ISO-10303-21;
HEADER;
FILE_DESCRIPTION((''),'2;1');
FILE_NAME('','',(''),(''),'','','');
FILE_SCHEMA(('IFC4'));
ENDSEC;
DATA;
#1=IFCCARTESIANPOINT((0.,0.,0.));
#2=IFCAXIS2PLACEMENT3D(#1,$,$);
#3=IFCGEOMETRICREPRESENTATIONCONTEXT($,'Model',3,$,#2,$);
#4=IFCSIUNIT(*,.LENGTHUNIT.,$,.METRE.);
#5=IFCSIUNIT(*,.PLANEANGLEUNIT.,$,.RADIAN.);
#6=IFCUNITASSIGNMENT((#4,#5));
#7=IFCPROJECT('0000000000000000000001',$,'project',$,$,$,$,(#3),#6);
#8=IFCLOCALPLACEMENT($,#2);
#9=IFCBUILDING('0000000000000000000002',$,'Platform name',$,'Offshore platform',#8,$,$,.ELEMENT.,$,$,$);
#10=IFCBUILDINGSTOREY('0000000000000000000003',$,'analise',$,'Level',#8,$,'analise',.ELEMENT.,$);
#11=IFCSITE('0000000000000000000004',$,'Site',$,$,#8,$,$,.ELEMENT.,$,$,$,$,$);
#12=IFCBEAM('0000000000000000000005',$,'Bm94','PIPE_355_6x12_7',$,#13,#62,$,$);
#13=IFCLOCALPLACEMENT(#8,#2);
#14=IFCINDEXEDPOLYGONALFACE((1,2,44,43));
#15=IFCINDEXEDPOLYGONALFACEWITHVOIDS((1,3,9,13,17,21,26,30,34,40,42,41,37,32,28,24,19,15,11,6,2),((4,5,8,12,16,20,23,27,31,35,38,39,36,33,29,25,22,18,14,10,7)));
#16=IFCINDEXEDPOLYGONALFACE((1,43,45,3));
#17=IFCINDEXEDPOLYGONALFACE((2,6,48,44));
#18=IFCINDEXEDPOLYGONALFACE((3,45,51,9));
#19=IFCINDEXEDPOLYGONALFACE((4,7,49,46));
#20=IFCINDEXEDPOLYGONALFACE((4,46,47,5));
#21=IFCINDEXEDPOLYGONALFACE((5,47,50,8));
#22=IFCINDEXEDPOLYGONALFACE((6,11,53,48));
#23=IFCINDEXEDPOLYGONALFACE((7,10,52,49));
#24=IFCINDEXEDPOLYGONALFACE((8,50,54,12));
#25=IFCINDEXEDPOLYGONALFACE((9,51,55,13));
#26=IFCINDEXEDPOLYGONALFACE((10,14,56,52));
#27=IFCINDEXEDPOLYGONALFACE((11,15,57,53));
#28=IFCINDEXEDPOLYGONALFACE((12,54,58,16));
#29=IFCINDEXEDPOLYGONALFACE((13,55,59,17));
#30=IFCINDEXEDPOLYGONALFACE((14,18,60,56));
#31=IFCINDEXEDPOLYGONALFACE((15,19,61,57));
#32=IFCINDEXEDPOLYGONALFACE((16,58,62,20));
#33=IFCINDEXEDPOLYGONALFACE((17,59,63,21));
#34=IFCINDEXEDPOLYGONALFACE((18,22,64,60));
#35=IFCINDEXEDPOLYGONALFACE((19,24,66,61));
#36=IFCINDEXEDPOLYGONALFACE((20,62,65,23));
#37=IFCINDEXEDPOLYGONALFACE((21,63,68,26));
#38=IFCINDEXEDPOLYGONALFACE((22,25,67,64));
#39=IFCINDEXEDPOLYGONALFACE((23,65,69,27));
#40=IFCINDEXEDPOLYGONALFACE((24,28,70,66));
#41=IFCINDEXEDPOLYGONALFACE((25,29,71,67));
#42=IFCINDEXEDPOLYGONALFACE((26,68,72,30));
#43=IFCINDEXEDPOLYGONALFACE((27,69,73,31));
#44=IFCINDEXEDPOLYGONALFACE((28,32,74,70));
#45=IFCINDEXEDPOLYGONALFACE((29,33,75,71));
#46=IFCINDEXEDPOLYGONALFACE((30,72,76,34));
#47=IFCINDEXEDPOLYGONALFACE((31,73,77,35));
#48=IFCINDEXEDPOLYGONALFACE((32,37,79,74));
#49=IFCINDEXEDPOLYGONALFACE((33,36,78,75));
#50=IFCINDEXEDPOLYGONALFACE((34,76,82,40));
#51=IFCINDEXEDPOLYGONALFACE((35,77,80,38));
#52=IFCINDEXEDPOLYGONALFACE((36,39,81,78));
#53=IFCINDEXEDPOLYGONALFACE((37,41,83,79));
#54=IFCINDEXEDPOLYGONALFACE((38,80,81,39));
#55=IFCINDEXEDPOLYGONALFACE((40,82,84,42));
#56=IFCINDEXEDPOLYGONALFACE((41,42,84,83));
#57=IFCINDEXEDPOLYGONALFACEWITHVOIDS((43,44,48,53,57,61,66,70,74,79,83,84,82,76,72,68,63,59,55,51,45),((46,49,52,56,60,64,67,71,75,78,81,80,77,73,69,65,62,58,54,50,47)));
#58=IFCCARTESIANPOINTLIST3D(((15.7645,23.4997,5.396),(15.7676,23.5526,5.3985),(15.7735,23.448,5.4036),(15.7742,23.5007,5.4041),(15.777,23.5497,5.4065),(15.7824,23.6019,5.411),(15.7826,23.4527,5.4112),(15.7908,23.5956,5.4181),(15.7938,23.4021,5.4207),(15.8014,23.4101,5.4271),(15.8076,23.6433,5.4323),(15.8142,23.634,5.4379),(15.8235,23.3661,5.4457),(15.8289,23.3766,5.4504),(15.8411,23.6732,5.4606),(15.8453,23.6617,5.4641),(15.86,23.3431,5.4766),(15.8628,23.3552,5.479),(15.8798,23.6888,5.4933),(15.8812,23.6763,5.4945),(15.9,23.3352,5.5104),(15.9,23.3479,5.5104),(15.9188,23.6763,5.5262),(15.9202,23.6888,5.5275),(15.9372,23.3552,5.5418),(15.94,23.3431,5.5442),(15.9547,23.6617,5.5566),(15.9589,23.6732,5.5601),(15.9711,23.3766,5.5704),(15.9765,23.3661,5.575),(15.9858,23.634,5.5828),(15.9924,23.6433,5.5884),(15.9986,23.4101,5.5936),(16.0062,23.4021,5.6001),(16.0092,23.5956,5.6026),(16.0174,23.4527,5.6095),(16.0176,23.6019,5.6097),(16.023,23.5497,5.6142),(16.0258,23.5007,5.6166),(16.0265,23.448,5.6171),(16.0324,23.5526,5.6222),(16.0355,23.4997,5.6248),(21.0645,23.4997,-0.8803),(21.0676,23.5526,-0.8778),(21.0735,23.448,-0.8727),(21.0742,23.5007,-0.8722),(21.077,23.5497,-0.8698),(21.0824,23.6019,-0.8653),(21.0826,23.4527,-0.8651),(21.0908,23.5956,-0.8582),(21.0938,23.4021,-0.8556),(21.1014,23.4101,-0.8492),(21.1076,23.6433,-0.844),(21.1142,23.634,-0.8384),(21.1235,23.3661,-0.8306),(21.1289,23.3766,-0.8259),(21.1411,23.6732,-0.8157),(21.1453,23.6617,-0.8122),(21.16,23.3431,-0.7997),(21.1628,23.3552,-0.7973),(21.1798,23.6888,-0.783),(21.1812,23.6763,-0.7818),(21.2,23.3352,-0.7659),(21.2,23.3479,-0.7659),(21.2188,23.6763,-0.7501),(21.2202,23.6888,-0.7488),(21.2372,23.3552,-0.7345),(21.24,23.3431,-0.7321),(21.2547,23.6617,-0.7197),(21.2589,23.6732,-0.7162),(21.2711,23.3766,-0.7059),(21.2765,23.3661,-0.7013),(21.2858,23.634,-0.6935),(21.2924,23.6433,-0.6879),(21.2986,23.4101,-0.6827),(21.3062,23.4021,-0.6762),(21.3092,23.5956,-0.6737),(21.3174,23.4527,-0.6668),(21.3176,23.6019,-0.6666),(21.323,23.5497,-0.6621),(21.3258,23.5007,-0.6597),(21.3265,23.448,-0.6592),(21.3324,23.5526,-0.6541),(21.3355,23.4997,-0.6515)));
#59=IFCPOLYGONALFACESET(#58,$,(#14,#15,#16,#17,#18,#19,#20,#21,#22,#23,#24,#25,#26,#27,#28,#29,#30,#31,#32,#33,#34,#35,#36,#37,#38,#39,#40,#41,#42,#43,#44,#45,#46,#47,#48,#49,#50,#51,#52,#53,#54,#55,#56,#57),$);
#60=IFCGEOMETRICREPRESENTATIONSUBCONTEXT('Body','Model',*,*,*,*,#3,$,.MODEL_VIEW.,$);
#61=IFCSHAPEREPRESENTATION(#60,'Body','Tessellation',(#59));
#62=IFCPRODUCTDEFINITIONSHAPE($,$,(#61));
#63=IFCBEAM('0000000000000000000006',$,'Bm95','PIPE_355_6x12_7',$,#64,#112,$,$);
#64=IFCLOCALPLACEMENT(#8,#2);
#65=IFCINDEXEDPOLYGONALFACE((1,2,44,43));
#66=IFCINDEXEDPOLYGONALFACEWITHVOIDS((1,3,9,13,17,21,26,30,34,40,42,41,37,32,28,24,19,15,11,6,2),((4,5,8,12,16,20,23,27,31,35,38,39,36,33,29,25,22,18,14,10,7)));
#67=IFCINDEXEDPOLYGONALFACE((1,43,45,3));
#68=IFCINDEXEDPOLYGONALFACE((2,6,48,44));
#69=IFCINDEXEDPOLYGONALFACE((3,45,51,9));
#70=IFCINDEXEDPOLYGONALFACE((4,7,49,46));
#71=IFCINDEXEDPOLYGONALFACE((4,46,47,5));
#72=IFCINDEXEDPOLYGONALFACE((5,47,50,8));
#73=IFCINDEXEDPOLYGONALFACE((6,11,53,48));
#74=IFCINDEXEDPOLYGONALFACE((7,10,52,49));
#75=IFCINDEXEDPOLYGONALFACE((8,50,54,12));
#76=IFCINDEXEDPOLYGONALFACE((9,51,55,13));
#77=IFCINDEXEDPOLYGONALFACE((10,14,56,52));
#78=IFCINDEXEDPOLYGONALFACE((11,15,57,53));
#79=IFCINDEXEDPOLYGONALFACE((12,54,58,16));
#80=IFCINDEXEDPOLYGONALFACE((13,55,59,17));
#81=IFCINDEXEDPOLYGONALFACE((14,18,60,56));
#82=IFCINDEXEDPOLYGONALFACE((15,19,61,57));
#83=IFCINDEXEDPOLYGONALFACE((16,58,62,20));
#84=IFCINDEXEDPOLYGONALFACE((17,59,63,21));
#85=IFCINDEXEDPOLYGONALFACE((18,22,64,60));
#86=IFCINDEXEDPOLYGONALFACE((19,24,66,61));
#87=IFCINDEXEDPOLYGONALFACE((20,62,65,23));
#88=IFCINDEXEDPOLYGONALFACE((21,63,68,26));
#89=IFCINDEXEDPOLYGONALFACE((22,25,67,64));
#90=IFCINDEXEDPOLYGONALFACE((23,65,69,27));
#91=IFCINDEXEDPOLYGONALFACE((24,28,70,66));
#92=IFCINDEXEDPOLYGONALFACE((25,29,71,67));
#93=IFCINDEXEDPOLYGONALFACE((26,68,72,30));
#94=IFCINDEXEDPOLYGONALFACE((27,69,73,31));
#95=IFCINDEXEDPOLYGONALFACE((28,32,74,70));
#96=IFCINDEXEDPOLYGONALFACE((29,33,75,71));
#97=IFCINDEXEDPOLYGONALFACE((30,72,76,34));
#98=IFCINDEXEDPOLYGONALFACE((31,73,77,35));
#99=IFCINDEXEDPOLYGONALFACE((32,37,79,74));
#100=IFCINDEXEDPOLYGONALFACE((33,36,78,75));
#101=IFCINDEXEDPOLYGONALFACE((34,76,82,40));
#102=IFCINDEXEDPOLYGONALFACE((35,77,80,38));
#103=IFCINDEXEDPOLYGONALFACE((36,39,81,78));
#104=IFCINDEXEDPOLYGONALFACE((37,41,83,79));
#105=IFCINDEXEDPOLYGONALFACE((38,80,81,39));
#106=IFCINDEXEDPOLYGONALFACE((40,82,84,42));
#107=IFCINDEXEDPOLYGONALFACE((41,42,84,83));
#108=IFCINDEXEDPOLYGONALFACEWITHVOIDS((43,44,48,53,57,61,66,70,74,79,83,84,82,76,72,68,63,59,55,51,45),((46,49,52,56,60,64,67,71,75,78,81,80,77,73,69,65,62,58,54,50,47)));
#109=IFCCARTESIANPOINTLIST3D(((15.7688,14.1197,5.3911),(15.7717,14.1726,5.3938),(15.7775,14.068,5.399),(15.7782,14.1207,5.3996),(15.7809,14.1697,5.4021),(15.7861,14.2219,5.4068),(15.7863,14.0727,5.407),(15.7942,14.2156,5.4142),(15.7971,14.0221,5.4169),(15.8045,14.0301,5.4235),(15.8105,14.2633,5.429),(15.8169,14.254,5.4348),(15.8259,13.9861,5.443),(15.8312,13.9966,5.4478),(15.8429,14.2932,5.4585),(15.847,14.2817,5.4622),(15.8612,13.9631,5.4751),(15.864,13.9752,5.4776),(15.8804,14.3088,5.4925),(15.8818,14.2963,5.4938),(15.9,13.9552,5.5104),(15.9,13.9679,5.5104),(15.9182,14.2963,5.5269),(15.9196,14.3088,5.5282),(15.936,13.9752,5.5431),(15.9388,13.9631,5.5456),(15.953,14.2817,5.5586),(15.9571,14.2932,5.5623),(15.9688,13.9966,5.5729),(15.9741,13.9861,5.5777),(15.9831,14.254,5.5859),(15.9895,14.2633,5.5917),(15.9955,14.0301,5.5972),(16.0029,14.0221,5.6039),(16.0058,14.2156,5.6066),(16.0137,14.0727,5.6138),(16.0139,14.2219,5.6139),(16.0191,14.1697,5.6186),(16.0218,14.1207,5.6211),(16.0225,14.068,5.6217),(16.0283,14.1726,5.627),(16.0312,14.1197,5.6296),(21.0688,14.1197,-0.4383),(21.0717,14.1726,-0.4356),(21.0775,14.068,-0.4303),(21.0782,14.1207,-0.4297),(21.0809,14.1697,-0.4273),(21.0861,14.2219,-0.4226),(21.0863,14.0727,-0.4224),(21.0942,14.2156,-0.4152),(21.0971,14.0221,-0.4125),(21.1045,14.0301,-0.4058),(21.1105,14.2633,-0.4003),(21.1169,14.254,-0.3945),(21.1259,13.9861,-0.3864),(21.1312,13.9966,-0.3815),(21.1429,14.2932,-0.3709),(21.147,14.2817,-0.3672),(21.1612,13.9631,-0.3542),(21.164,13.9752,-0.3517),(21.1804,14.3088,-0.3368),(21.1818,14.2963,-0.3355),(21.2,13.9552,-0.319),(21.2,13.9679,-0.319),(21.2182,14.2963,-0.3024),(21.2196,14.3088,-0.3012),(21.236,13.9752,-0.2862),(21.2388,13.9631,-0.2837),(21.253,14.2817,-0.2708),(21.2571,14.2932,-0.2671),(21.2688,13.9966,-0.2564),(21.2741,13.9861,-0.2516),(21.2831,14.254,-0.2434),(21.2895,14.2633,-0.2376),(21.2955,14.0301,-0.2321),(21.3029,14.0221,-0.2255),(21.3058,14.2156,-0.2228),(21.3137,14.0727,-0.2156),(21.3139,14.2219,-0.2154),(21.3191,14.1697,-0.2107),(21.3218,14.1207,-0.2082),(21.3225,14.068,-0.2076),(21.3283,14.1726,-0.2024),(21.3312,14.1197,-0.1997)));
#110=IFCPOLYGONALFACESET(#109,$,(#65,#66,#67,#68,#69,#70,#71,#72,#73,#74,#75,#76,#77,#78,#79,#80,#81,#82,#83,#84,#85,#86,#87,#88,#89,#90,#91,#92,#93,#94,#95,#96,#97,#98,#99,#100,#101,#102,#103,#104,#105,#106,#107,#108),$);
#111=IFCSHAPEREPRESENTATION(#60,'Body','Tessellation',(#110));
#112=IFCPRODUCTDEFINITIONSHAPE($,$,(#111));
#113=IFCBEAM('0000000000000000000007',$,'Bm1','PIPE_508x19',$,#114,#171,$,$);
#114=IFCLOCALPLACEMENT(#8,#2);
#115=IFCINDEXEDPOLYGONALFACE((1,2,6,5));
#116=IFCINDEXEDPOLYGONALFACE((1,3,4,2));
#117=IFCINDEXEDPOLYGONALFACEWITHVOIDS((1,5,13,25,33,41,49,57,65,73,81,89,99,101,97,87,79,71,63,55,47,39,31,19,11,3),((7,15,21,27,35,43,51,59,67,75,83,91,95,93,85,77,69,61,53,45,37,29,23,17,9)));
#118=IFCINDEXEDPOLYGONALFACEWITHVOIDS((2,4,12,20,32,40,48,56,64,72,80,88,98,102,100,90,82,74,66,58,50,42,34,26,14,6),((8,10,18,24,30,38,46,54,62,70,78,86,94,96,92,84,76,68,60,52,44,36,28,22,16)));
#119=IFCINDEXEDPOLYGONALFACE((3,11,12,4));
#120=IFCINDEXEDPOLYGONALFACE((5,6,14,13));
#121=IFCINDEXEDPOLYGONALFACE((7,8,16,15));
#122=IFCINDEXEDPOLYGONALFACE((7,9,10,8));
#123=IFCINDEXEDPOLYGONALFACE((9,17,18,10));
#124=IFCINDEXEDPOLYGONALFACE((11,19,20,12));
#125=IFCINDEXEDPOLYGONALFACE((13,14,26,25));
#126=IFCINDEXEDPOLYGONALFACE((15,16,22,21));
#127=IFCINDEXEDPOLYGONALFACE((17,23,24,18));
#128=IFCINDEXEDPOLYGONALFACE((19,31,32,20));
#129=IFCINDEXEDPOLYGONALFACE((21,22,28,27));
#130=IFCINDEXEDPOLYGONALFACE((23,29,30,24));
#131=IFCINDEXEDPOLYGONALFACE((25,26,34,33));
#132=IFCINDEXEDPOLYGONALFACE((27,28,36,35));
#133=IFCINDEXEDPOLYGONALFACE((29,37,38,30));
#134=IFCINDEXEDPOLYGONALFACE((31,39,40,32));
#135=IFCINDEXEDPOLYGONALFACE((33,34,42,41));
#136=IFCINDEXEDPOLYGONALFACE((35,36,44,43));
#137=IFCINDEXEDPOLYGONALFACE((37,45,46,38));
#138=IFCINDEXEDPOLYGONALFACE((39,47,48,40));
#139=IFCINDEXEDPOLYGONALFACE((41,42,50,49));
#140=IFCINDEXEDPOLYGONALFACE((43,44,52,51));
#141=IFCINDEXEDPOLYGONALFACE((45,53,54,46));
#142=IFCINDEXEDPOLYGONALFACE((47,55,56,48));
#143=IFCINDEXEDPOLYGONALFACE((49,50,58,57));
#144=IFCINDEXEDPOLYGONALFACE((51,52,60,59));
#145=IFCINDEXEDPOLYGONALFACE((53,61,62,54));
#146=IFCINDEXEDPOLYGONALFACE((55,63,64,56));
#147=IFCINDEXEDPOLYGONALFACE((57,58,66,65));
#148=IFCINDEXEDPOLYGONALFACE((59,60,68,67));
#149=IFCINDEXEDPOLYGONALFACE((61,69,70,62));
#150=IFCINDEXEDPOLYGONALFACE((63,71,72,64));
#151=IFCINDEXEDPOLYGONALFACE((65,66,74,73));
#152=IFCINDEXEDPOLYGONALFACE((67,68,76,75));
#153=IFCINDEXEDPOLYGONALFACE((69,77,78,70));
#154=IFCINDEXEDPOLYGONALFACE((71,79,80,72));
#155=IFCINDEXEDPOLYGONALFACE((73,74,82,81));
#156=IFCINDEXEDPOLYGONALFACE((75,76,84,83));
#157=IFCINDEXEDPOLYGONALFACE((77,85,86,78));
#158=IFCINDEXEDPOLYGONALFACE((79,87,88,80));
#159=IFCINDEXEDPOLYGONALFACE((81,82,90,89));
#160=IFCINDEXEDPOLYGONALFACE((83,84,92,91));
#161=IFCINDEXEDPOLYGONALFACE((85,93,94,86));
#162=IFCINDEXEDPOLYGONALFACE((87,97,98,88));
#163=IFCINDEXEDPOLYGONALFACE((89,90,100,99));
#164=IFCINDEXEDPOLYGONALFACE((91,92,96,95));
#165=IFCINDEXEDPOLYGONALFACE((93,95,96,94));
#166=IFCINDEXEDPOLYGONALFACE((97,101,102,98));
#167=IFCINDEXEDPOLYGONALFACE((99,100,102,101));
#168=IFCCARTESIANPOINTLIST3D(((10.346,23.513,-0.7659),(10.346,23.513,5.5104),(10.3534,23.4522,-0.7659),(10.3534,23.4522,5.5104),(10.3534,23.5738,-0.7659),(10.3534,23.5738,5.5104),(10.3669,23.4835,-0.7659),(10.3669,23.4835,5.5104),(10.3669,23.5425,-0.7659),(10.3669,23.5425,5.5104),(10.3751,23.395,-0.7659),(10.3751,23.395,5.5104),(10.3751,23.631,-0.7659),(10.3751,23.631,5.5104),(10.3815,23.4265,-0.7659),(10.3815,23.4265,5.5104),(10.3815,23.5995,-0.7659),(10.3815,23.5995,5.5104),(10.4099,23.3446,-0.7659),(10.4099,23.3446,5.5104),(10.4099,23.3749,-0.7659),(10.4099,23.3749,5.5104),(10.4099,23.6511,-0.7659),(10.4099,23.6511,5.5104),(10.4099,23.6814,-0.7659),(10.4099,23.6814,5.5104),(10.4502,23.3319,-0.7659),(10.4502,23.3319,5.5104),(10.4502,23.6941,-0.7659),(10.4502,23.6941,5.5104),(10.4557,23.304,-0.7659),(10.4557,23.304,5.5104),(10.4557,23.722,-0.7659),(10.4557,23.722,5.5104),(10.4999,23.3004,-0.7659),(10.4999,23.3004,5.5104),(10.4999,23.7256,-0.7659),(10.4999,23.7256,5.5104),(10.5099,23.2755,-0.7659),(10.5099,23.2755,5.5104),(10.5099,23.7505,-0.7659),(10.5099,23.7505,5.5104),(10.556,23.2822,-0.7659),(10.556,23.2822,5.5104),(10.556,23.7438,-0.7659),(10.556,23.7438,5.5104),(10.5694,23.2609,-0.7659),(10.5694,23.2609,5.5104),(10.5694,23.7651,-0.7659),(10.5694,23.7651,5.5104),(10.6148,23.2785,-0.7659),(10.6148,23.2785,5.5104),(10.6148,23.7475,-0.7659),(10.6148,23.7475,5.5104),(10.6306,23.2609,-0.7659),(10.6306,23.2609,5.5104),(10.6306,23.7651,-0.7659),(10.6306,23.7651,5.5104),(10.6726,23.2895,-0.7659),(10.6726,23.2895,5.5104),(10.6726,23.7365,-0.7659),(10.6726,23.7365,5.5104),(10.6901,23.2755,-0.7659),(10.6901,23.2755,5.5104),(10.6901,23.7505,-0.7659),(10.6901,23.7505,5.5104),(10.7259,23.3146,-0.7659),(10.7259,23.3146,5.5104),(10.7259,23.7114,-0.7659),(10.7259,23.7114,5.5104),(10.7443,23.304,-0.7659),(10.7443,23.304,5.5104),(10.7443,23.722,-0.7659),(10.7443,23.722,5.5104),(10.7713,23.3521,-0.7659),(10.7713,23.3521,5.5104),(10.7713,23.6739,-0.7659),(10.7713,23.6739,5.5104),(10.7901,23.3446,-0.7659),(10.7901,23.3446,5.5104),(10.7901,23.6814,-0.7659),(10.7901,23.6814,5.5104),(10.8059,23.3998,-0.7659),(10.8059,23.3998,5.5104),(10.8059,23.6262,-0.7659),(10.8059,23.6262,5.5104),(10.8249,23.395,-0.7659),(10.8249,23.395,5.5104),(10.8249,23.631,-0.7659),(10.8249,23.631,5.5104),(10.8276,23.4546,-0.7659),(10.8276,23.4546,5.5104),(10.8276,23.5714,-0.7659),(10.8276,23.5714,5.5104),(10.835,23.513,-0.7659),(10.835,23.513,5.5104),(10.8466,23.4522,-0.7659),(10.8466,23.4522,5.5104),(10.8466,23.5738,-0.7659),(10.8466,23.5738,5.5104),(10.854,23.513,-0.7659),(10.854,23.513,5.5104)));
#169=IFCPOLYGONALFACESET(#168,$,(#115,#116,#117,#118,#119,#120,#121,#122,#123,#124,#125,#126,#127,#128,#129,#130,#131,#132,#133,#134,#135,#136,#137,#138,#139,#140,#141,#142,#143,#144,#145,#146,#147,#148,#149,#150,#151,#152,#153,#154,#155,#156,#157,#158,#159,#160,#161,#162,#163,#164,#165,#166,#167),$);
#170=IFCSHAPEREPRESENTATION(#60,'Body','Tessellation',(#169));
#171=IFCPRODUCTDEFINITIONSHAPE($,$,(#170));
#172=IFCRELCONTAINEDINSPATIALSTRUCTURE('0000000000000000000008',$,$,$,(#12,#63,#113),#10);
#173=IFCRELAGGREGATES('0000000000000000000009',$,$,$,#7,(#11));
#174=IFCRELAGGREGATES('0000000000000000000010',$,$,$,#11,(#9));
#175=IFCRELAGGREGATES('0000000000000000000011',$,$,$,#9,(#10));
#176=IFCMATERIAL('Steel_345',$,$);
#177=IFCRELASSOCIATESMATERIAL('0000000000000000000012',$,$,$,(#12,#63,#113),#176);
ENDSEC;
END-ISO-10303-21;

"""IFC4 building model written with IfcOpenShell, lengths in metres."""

from ifc_helpers import new_model, si_unit, frame, origin, origin_with_axes, origin_2d, place, context, subcontext, project, spatial, hollow_circle, extrude, source, transform, mapped, material, element, save


model = new_model("IFC4")

# Units and contexts
model_context = context("Model", 3, world=origin())
body_context = subcontext(model_context, "Body", "Model", "MODEL_VIEW")
ifc_project = project(units=[si_unit("LENGTHUNIT", "METRE"), si_unit("PLANEANGLEUNIT", "RADIAN")], contexts=[model_context])

# Site, building, storey
placement_1 = place(None, origin())
site = spatial("IfcSite", under=ifc_project, at=placement_1, Name="Site", CompositionType="ELEMENT")
building = spatial("IfcBuilding", under=site, at=placement_1, Name="Platform name", ObjectType="Offshore platform", CompositionType="ELEMENT")
storey = spatial("IfcBuildingStorey", under=building, at=placement_1, Name="analise", ObjectType="Level", LongName="analise", CompositionType="ELEMENT")

# Beams
ifc_material_1 = material(Name="Steel_345")
shared_shape_1 = source(origin(), body_context, "Body", "SweptSolid", [
    extrude(hollow_circle(Radius=0.1778, WallThickness=0.0127, at=origin_2d()), frame((0.0, 0.0, 0.0), z_axis=(-0.645182, 0.0, 0.764029), x_axis=(0.0, -1.0, 0.0)), (0.0, 0.0, 1.0), 8.2147),
])
placement_2 = place(None, origin())
placement_3 = place(placement_2, origin())
placement_4 = place(placement_3, origin())
beam_1_placement = place(placement_4, frame((21.2, 23.513, -0.7659)))
element("IfcBeam", 1, at=beam_1_placement, inside=storey, material=ifc_material_1, Name="Bm94", Description="PIPE_355_6x12_7", context=body_context, shape_type="MappedRepresentation", body=[
    mapped(shared_shape_1, transform((0.0, 0.0, 0.0), scale=1.0)),
])
shared_shape_2 = source(origin(), body_context, "Body", "SweptSolid", [
    extrude(hollow_circle(Radius=0.1778, WallThickness=0.0127, at=origin_2d()), frame((0.0, 0.0, 0.0), z_axis=(-0.672714, 0.0, 0.739903), x_axis=(0.0, -1.0, 0.0)), (0.0, 0.0, 1.0), 7.8785),
])
placement_5 = place(None, origin())
placement_6 = place(placement_5, origin())
placement_7 = place(placement_6, origin())
beam_2_placement = place(placement_7, frame((21.2, 14.133, -0.319)))
element("IfcBeam", 2, at=beam_2_placement, inside=storey, material=ifc_material_1, Name="Bm95", Description="PIPE_355_6x12_7", context=body_context, shape_type="MappedRepresentation", body=[
    mapped(shared_shape_2, transform((0.0, 0.0, 0.0), scale=1.0)),
])
shared_shape_3 = source(origin(), body_context, "Body", "SweptSolid", [
    extrude(hollow_circle(Radius=0.254, WallThickness=0.019, at=origin_2d()), origin_with_axes(), (0.0, 0.0, 1.0), 6.2763),
])
placement_8 = place(None, origin())
placement_9 = place(placement_8, origin())
placement_10 = place(placement_9, origin())
beam_3_placement = place(placement_10, frame((10.6, 23.513, -0.7659)))
element("IfcBeam", 3, at=beam_3_placement, inside=storey, material=ifc_material_1, Name="Bm1", Description="PIPE_508x19", context=body_context, shape_type="MappedRepresentation", body=[
    mapped(shared_shape_3, transform((0.0, 0.0, 0.0), scale=1.0)),
])

save(model, "model.ifc")
